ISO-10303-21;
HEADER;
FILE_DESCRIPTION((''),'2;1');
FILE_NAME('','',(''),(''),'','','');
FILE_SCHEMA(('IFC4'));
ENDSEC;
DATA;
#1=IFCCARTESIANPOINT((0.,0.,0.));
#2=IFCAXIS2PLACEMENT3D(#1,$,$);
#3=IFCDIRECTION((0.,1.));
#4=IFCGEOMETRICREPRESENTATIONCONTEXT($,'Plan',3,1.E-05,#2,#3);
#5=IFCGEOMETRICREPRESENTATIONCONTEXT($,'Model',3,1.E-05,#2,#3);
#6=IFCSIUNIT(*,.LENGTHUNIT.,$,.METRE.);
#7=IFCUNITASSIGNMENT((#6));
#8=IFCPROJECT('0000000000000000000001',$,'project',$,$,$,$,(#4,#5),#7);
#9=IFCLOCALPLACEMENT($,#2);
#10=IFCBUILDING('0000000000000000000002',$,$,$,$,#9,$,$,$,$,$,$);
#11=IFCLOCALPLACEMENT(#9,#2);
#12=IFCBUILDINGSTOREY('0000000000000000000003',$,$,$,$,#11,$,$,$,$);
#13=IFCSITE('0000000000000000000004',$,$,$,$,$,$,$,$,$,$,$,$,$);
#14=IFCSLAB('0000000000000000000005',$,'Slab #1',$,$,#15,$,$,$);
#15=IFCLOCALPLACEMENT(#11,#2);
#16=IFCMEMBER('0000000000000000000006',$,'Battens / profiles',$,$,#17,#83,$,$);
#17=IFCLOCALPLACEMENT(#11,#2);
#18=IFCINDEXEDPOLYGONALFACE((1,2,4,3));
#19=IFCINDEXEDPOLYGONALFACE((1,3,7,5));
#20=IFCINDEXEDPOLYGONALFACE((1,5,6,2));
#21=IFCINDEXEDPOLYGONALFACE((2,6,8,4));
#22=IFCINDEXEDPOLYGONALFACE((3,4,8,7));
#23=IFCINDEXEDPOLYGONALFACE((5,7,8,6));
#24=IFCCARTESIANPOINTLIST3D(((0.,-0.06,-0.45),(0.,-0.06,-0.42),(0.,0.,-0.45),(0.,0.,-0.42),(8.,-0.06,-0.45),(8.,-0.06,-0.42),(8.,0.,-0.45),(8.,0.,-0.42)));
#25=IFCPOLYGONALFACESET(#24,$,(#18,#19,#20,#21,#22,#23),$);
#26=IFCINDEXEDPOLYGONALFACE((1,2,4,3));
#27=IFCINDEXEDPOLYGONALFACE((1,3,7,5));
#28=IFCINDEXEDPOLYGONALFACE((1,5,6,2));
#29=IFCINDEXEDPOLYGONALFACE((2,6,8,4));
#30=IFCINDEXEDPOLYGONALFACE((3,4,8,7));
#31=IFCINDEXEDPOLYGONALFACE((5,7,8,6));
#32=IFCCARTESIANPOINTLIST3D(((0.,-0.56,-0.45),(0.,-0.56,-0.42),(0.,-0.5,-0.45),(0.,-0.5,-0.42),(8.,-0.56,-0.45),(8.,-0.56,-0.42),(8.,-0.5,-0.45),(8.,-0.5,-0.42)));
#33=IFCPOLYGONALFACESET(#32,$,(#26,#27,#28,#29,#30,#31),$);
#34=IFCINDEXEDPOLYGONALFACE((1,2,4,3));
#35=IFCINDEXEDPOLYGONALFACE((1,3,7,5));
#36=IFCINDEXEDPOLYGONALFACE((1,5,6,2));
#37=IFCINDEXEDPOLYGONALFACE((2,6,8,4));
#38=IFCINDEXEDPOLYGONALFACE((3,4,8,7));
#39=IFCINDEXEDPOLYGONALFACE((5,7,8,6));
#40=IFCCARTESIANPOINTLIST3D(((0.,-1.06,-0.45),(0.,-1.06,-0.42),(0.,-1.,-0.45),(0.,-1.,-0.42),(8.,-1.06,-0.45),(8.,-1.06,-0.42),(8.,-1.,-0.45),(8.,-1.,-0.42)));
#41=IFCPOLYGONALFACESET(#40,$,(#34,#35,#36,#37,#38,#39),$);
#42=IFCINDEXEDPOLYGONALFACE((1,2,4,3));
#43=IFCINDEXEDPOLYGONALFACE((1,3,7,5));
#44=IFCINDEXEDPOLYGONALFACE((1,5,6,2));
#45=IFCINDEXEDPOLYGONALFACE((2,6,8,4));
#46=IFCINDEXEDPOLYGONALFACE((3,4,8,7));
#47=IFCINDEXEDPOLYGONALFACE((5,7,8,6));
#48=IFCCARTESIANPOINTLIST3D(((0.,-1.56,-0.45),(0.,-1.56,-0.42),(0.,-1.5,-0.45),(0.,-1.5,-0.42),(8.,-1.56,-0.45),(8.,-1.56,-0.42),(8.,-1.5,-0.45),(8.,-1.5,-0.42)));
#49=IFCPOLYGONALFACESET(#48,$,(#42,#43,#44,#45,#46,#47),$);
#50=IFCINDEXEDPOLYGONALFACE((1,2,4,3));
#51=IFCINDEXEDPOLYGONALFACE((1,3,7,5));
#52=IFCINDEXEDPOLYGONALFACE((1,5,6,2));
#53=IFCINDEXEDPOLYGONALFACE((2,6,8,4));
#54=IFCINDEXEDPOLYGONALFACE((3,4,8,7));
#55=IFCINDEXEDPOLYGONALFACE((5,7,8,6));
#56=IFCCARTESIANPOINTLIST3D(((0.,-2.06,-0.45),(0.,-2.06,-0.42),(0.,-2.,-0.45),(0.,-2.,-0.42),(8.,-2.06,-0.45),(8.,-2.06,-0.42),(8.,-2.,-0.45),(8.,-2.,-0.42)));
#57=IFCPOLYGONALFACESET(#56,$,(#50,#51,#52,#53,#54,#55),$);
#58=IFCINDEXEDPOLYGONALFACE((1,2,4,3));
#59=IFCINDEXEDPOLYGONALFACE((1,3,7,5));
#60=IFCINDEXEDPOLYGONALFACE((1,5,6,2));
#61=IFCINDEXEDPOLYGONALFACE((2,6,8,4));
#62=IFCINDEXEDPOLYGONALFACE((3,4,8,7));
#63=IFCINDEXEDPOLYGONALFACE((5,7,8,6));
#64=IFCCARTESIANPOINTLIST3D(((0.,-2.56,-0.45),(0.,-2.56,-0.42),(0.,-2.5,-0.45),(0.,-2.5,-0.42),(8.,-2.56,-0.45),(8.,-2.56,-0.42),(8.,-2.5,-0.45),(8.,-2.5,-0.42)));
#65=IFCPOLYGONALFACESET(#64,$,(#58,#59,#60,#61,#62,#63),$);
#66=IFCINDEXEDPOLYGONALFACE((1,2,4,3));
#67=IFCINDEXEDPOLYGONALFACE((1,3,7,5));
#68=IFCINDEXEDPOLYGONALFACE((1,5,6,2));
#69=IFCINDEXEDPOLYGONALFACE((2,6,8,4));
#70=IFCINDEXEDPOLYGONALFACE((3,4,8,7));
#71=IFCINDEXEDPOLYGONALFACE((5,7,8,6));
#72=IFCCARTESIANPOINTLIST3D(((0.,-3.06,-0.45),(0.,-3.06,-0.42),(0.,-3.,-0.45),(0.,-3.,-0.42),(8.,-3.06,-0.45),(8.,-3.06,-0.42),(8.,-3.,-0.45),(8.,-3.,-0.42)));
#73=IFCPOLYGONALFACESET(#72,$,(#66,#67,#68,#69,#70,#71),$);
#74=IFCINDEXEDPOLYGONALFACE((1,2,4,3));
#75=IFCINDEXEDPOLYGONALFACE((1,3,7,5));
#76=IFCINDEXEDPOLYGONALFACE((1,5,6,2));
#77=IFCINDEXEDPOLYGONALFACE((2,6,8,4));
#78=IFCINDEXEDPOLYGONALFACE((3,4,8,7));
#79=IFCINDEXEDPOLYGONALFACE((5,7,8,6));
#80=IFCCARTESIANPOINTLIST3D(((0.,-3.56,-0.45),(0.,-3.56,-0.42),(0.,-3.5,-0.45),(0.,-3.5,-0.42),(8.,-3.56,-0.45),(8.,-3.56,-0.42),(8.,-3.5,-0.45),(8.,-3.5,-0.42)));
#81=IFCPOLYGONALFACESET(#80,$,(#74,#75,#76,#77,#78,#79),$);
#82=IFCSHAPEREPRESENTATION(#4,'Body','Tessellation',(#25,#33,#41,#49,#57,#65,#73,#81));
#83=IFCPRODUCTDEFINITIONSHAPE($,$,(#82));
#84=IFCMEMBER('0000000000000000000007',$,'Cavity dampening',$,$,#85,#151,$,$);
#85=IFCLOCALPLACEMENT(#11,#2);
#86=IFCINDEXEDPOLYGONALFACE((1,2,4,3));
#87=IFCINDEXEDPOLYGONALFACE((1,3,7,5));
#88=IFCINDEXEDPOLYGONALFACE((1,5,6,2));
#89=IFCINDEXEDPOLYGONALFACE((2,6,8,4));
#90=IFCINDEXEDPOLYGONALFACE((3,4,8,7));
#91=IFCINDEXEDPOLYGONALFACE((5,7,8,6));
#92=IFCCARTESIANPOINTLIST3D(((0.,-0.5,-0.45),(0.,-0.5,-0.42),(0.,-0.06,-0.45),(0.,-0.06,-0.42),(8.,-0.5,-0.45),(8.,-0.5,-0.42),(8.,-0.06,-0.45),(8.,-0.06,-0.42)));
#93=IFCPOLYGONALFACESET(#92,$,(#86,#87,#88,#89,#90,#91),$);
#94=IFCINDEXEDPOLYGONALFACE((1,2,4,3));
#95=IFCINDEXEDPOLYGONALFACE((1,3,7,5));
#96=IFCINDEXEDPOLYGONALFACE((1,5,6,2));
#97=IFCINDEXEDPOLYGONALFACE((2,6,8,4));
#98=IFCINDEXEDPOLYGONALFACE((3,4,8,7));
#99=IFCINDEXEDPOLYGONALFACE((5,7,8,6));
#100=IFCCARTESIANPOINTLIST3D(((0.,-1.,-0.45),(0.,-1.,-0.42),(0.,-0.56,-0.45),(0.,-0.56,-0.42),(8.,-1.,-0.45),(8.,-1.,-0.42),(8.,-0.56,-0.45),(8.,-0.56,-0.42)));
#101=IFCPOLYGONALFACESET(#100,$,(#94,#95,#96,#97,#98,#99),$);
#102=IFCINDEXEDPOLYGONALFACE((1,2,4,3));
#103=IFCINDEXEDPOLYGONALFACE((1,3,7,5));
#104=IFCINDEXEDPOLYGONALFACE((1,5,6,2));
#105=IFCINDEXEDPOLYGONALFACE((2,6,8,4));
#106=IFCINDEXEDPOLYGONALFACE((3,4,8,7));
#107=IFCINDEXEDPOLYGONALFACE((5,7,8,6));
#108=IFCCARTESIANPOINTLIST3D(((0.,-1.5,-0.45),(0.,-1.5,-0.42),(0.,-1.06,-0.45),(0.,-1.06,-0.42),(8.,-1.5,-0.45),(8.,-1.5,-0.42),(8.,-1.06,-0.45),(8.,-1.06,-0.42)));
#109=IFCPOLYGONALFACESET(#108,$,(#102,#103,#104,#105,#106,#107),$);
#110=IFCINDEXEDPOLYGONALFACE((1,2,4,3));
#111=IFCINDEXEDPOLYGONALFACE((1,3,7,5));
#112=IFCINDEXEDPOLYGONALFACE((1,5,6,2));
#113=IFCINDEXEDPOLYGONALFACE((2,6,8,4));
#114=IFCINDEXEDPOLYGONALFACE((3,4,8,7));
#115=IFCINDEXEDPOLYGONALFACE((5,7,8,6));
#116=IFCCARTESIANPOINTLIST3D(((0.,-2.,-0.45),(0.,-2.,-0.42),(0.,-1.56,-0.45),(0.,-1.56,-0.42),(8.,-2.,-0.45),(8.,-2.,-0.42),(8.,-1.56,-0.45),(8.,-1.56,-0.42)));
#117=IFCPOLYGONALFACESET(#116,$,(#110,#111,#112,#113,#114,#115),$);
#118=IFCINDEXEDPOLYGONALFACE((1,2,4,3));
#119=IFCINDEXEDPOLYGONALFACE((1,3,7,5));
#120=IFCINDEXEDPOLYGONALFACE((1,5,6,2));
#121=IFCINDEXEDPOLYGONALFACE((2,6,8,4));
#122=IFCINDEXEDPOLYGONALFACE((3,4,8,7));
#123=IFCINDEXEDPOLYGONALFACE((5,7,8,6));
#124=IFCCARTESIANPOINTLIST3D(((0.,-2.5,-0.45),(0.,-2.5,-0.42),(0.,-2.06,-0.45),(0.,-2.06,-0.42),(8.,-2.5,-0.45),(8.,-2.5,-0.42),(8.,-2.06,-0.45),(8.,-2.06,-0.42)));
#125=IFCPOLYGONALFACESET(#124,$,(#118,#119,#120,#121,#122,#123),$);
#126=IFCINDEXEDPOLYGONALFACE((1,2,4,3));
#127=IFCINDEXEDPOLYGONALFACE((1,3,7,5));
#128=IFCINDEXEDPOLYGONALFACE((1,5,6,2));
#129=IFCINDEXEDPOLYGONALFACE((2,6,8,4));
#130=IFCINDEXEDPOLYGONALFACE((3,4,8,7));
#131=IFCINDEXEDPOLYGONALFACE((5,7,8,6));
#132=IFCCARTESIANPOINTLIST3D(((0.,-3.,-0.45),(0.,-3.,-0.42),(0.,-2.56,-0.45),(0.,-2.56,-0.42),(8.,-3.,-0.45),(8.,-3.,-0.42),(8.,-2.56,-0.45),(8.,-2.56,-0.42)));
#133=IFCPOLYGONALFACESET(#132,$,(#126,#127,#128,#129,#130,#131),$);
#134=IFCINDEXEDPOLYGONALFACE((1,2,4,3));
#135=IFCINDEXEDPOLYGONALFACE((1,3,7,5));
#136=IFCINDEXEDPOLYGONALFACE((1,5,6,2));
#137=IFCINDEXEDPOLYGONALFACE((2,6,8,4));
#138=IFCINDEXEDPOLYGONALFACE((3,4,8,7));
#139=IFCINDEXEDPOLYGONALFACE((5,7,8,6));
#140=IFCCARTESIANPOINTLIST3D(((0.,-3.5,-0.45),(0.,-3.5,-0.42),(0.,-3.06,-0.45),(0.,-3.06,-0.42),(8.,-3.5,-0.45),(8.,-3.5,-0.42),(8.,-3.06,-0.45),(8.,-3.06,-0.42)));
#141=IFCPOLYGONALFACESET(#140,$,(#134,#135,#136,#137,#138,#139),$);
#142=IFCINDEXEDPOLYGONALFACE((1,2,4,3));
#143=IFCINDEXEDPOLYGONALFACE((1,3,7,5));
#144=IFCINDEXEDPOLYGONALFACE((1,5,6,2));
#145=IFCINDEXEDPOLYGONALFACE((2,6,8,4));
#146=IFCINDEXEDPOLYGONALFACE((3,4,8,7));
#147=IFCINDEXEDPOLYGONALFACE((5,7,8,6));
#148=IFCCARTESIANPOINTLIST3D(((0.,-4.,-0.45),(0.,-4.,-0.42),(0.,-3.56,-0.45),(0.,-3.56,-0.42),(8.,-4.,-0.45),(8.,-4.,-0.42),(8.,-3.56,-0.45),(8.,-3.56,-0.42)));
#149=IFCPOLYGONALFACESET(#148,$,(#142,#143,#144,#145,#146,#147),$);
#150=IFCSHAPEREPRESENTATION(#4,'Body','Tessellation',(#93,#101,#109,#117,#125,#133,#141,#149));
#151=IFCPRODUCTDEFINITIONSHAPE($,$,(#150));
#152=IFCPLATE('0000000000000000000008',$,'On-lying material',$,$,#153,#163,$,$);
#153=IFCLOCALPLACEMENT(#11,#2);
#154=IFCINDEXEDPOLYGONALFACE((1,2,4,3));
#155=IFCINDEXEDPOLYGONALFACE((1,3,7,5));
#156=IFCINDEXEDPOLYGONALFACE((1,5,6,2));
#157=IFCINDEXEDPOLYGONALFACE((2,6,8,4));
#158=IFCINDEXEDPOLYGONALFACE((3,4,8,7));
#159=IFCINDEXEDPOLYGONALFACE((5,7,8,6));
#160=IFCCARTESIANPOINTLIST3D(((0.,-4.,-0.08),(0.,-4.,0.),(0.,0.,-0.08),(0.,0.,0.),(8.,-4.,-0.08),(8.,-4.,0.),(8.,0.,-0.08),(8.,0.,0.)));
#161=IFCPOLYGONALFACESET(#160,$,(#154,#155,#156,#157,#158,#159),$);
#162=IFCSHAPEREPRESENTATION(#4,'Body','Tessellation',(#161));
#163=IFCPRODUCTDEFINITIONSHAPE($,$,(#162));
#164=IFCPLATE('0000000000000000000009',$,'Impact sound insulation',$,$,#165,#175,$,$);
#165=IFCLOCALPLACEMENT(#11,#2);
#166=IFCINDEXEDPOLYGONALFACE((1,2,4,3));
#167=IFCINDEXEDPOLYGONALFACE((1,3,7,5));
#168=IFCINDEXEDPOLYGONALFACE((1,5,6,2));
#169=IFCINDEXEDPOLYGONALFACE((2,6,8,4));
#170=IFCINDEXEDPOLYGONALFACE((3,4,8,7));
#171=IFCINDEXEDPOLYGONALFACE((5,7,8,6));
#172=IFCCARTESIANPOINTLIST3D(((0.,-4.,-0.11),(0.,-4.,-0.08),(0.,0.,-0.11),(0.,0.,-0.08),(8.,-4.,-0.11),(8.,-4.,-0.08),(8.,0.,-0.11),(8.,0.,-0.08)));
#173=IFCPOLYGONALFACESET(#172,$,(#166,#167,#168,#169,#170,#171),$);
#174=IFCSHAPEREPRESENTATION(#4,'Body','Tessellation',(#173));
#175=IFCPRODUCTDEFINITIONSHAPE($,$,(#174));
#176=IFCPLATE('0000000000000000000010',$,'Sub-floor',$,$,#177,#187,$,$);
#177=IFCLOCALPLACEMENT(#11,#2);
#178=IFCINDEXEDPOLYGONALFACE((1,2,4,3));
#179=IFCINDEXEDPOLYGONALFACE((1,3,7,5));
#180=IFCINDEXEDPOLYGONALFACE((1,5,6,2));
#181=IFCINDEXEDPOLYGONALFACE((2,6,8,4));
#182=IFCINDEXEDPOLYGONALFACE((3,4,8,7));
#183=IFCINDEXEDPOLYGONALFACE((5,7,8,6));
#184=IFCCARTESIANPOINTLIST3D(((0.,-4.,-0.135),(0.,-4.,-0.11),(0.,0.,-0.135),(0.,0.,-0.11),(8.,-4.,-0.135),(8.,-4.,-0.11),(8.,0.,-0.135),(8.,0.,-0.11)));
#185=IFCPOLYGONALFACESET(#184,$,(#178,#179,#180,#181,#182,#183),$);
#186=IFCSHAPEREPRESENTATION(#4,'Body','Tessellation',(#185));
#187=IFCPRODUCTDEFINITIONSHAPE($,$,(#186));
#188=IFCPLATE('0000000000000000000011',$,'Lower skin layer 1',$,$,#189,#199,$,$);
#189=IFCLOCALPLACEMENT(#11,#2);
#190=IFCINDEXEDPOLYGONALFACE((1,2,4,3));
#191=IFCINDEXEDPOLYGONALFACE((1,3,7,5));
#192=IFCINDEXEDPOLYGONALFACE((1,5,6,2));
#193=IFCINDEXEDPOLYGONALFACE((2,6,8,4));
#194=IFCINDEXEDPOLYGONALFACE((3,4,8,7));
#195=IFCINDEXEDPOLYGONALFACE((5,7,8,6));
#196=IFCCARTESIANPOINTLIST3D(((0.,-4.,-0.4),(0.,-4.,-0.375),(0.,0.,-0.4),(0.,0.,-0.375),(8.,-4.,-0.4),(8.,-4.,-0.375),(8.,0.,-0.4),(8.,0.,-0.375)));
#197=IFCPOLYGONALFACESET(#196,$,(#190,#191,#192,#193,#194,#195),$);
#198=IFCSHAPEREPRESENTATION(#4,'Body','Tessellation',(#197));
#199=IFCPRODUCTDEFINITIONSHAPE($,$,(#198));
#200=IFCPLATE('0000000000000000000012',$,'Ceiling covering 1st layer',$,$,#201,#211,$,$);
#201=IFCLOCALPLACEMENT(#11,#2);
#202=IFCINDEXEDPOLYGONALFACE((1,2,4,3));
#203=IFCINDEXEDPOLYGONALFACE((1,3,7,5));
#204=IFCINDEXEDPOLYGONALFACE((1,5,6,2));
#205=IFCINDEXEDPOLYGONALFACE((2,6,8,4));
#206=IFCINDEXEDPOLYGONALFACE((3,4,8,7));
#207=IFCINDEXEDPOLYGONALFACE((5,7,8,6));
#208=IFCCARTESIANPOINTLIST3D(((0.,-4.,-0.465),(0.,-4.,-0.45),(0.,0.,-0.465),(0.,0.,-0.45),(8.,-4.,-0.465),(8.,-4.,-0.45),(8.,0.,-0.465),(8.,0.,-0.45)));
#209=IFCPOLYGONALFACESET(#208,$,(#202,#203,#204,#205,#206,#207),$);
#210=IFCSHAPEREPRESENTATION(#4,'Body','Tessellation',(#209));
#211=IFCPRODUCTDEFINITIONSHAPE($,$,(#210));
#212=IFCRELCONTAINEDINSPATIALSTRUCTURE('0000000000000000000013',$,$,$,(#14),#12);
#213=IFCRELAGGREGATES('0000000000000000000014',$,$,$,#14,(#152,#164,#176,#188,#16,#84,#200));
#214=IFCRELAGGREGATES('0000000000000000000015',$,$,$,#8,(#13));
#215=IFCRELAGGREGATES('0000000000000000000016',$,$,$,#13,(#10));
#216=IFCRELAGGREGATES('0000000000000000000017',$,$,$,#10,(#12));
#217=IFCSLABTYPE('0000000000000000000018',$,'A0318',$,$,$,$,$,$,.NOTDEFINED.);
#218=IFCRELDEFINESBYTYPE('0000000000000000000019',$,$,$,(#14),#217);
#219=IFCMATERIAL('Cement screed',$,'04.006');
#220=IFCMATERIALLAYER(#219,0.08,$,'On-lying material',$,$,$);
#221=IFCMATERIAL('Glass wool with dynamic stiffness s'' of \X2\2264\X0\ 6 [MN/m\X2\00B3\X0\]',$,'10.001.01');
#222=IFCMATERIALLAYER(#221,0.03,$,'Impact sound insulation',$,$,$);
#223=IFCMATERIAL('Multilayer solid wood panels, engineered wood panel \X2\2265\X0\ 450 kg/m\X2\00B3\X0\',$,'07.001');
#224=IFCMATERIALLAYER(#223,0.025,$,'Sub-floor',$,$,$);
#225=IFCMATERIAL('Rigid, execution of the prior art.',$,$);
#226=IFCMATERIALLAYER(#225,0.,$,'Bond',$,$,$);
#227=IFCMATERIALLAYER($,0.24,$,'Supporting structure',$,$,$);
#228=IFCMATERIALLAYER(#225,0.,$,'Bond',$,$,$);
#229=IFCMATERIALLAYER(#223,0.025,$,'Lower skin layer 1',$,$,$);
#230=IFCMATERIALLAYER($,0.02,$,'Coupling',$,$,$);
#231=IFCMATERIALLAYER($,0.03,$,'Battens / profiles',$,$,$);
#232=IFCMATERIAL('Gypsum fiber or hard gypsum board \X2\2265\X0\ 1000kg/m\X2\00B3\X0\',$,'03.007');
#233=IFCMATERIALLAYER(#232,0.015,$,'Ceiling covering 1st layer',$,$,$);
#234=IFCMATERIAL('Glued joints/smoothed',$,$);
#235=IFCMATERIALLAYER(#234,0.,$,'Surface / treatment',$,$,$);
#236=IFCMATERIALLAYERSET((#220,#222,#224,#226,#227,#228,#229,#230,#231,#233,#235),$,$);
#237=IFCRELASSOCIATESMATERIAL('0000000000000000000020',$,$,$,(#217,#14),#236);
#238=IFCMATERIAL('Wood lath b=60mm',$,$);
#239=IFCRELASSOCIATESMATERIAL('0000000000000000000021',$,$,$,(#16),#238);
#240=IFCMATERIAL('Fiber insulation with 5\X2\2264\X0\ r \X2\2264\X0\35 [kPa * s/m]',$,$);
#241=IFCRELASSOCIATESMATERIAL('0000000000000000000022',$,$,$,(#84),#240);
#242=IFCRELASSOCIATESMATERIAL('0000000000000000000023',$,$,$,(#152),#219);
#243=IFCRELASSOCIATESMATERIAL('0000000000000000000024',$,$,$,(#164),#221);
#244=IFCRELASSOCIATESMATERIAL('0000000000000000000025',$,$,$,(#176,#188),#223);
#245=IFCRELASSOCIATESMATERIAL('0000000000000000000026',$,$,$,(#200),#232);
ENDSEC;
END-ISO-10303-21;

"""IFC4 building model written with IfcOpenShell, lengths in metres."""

from ifc_helpers import new_model, si_unit, direction, frame, frame_2d, origin, origin_with_axes, place, context, project, spatial, rectangle, extrude, material, layer, layer_set, type_object, element, aggregate, save


model = new_model("IFC4")

# Units and contexts
plan_context = context("Plan", 3, precision=1e-05, world=origin(), true_north=direction((0.0, 1.0)))
model_context = context("Model", 3, precision=1e-05, world=origin(), true_north=direction((0.0, 1.0)))
ifc_project = project(units=[si_unit("LENGTHUNIT", "METRE")], contexts=[plan_context, model_context])

# Site, building, storey
site = spatial("IfcSite", under=ifc_project)
building_placement = place(None, origin())
building = spatial("IfcBuilding", under=site, at=building_placement)
storey_placement = place(building_placement, origin())
storey = spatial("IfcBuildingStorey", under=building, at=storey_placement)

# Slab, members, plates
ifc_material_1 = material(Name="Cement screed", Category="04.006")
ifc_layer_1 = layer(ifc_material_1, 0.08, Name="On-lying material")
ifc_material_2 = material(Name="Glass wool with dynamic stiffness s' of ≤ 6 [MN/m³]", Category="10.001.01")
ifc_layer_2 = layer(ifc_material_2, 0.03, Name="Impact sound insulation")
ifc_material_3 = material(Name="Multilayer solid wood panels, engineered wood panel ≥ 450 kg/m³", Category="07.001")
ifc_layer_3 = layer(ifc_material_3, 0.025, Name="Sub-floor")
ifc_material_4 = material(Name="Rigid, execution of the prior art.")
ifc_layer_4 = layer(ifc_material_4, 0.0, Name="Bond")
ifc_layer_5 = layer(None, 0.24, Name="Supporting structure")
ifc_layer_6 = layer(ifc_material_4, 0.0, Name="Bond")
ifc_layer_7 = layer(ifc_material_3, 0.025, Name="Lower skin layer 1")
ifc_layer_8 = layer(None, 0.02, Name="Coupling")
ifc_layer_9 = layer(None, 0.03, Name="Battens / profiles")
ifc_material_5 = material(Name="Gypsum fiber or hard gypsum board ≥ 1000kg/m³", Category="03.007")
ifc_layer_10 = layer(ifc_material_5, 0.015, Name="Ceiling covering 1st layer")
ifc_material_6 = material(Name="Glued joints/smoothed")
ifc_layer_11 = layer(ifc_material_6, 0.0, Name="Surface / treatment")
ifc_layer_set = layer_set([ifc_layer_1, ifc_layer_2, ifc_layer_3, ifc_layer_4, ifc_layer_5, ifc_layer_6, ifc_layer_7, ifc_layer_8, ifc_layer_9, ifc_layer_10, ifc_layer_11])
slab_type = type_object("IfcSlabType", Name="A0318", PredefinedType="NOTDEFINED", material=ifc_layer_set)
slab_placement = place(None, frame((0.0, 0.0, 0.0), z_axis=(0.0, 0.0, -1.0), x_axis=(1.0, 0.0, 0.0)))
slab = element("IfcSlab", 1, at=slab_placement, inside=storey, type_object=slab_type, material=ifc_layer_set, Name="Slab #1")
ifc_material_7 = material(Name="Fiber insulation with 5≤ r ≤35 [kPa * s/m]")
ifc_material_8 = material(Name="Wood lath b=60mm")
member_1_placement = place(slab_placement, origin())
member_1 = element("IfcMember", 2, at=member_1_placement, material=ifc_material_8, Name="Battens / profiles", context=plan_context, shape_type="SweptSolid", body=[
    extrude(rectangle(XDim=0.06, YDim=0.03, at=frame_2d((0.03, 0.015), x_axis=(1.0, 0.0))), frame((0.0, 0.0, 0.42), z_axis=(1.0, 0.0, 0.0), x_axis=(0.0, 1.0, 0.0)), (0.0, 0.0, 1.0), 8.0),
    extrude(rectangle(XDim=0.06, YDim=0.03, at=frame_2d((0.03, 0.015), x_axis=(1.0, 0.0))), frame((0.0, 0.5, 0.42), z_axis=(1.0, 0.0, 0.0), x_axis=(0.0, 1.0, 0.0)), (0.0, 0.0, 1.0), 8.0),
    extrude(rectangle(XDim=0.06, YDim=0.03, at=frame_2d((0.03, 0.015), x_axis=(1.0, 0.0))), frame((0.0, 1.0, 0.42), z_axis=(1.0, 0.0, 0.0), x_axis=(0.0, 1.0, 0.0)), (0.0, 0.0, 1.0), 8.0),
    extrude(rectangle(XDim=0.06, YDim=0.03, at=frame_2d((0.03, 0.015), x_axis=(1.0, 0.0))), frame((0.0, 1.5, 0.42), z_axis=(1.0, 0.0, 0.0), x_axis=(0.0, 1.0, 0.0)), (0.0, 0.0, 1.0), 8.0),
    extrude(rectangle(XDim=0.06, YDim=0.03, at=frame_2d((0.03, 0.015), x_axis=(1.0, 0.0))), frame((0.0, 2.0, 0.42), z_axis=(1.0, 0.0, 0.0), x_axis=(0.0, 1.0, 0.0)), (0.0, 0.0, 1.0), 8.0),
    extrude(rectangle(XDim=0.06, YDim=0.03, at=frame_2d((0.03, 0.015), x_axis=(1.0, 0.0))), frame((0.0, 2.5, 0.42), z_axis=(1.0, 0.0, 0.0), x_axis=(0.0, 1.0, 0.0)), (0.0, 0.0, 1.0), 8.0),
    extrude(rectangle(XDim=0.06, YDim=0.03, at=frame_2d((0.03, 0.015), x_axis=(1.0, 0.0))), frame((0.0, 3.0, 0.42), z_axis=(1.0, 0.0, 0.0), x_axis=(0.0, 1.0, 0.0)), (0.0, 0.0, 1.0), 8.0),
    extrude(rectangle(XDim=0.06, YDim=0.03, at=frame_2d((0.03, 0.015), x_axis=(1.0, 0.0))), frame((0.0, 3.5, 0.42), z_axis=(1.0, 0.0, 0.0), x_axis=(0.0, 1.0, 0.0)), (0.0, 0.0, 1.0), 8.0),
])
member_2_placement = place(slab_placement, origin())
member_2 = element("IfcMember", 3, at=member_2_placement, material=ifc_material_7, Name="Cavity dampening", context=plan_context, shape_type="SweptSolid", body=[
    extrude(rectangle(XDim=0.44, YDim=0.03, at=frame_2d((0.22, 0.015), x_axis=(1.0, 0.0))), frame((0.0, 0.06, 0.42), z_axis=(1.0, 0.0, 0.0), x_axis=(0.0, 1.0, 0.0)), (0.0, 0.0, 1.0), 8.0),
    extrude(rectangle(XDim=0.44, YDim=0.03, at=frame_2d((0.22, 0.015), x_axis=(1.0, 0.0))), frame((0.0, 0.56, 0.42), z_axis=(1.0, 0.0, 0.0), x_axis=(0.0, 1.0, 0.0)), (0.0, 0.0, 1.0), 8.0),
    extrude(rectangle(XDim=0.44, YDim=0.03, at=frame_2d((0.22, 0.015), x_axis=(1.0, 0.0))), frame((0.0, 1.06, 0.42), z_axis=(1.0, 0.0, 0.0), x_axis=(0.0, 1.0, 0.0)), (0.0, 0.0, 1.0), 8.0),
    extrude(rectangle(XDim=0.44, YDim=0.03, at=frame_2d((0.22, 0.015), x_axis=(1.0, 0.0))), frame((0.0, 1.56, 0.42), z_axis=(1.0, 0.0, 0.0), x_axis=(0.0, 1.0, 0.0)), (0.0, 0.0, 1.0), 8.0),
    extrude(rectangle(XDim=0.44, YDim=0.03, at=frame_2d((0.22, 0.015), x_axis=(1.0, 0.0))), frame((0.0, 2.06, 0.42), z_axis=(1.0, 0.0, 0.0), x_axis=(0.0, 1.0, 0.0)), (0.0, 0.0, 1.0), 8.0),
    extrude(rectangle(XDim=0.44, YDim=0.03, at=frame_2d((0.22, 0.015), x_axis=(1.0, 0.0))), frame((0.0, 2.56, 0.42), z_axis=(1.0, 0.0, 0.0), x_axis=(0.0, 1.0, 0.0)), (0.0, 0.0, 1.0), 8.0),
    extrude(rectangle(XDim=0.44, YDim=0.03, at=frame_2d((0.22, 0.015), x_axis=(1.0, 0.0))), frame((0.0, 3.06, 0.42), z_axis=(1.0, 0.0, 0.0), x_axis=(0.0, 1.0, 0.0)), (0.0, 0.0, 1.0), 8.0),
    extrude(rectangle(XDim=0.44, YDim=0.03, at=frame_2d((0.22, 0.015), x_axis=(1.0, 0.0))), frame((0.0, 3.56, 0.42), z_axis=(1.0, 0.0, 0.0), x_axis=(0.0, 1.0, 0.0)), (0.0, 0.0, 1.0), 8.0),
])
plate_1_placement = place(slab_placement, origin())
plate_1 = element("IfcPlate", 4, at=plate_1_placement, material=ifc_material_1, Name="On-lying material", context=plan_context, shape_type="SweptSolid", body=[
    extrude(rectangle(XDim=8.0, YDim=4.0, at=frame_2d((4.0, 2.0), x_axis=(1.0, 0.0))), origin_with_axes(), (0.0, 0.0, 1.0), 0.08),
])
plate_2_placement = place(slab_placement, origin())
plate_2 = element("IfcPlate", 5, at=plate_2_placement, material=ifc_material_2, Name="Impact sound insulation", context=plan_context, shape_type="SweptSolid", body=[
    extrude(rectangle(XDim=8.0, YDim=4.0, at=frame_2d((4.0, 2.0), x_axis=(1.0, 0.0))), frame((0.0, 0.0, 0.08), z_axis=(0.0, 0.0, 1.0), x_axis=(1.0, 0.0, 0.0)), (0.0, 0.0, 1.0), 0.03),
])
plate_3_placement = place(slab_placement, origin())
plate_3 = element("IfcPlate", 6, at=plate_3_placement, material=ifc_material_3, Name="Sub-floor", context=plan_context, shape_type="SweptSolid", body=[
    extrude(rectangle(XDim=8.0, YDim=4.0, at=frame_2d((4.0, 2.0), x_axis=(1.0, 0.0))), frame((0.0, 0.0, 0.11), z_axis=(0.0, 0.0, 1.0), x_axis=(1.0, 0.0, 0.0)), (0.0, 0.0, 1.0), 0.025),
])
plate_4_placement = place(slab_placement, origin())
plate_4 = element("IfcPlate", 7, at=plate_4_placement, material=ifc_material_3, Name="Lower skin layer 1", context=plan_context, shape_type="SweptSolid", body=[
    extrude(rectangle(XDim=8.0, YDim=4.0, at=frame_2d((4.0, 2.0), x_axis=(1.0, 0.0))), frame((0.0, 0.0, 0.375), z_axis=(0.0, 0.0, 1.0), x_axis=(1.0, 0.0, 0.0)), (0.0, 0.0, 1.0), 0.025),
])
plate_5_placement = place(slab_placement, origin())
plate_5 = element("IfcPlate", 8, at=plate_5_placement, material=ifc_material_5, Name="Ceiling covering 1st layer", context=plan_context, shape_type="SweptSolid", body=[
    extrude(rectangle(XDim=8.0, YDim=4.0, at=frame_2d((4.0, 2.0), x_axis=(1.0, 0.0))), frame((0.0, 0.0, 0.45), z_axis=(0.0, 0.0, 1.0), x_axis=(1.0, 0.0, 0.0)), (0.0, 0.0, 1.0), 0.015),
])
aggregate(slab, [plate_1, plate_2, plate_3, plate_4, member_1, member_2, plate_5])

save(model, "model.ifc")
